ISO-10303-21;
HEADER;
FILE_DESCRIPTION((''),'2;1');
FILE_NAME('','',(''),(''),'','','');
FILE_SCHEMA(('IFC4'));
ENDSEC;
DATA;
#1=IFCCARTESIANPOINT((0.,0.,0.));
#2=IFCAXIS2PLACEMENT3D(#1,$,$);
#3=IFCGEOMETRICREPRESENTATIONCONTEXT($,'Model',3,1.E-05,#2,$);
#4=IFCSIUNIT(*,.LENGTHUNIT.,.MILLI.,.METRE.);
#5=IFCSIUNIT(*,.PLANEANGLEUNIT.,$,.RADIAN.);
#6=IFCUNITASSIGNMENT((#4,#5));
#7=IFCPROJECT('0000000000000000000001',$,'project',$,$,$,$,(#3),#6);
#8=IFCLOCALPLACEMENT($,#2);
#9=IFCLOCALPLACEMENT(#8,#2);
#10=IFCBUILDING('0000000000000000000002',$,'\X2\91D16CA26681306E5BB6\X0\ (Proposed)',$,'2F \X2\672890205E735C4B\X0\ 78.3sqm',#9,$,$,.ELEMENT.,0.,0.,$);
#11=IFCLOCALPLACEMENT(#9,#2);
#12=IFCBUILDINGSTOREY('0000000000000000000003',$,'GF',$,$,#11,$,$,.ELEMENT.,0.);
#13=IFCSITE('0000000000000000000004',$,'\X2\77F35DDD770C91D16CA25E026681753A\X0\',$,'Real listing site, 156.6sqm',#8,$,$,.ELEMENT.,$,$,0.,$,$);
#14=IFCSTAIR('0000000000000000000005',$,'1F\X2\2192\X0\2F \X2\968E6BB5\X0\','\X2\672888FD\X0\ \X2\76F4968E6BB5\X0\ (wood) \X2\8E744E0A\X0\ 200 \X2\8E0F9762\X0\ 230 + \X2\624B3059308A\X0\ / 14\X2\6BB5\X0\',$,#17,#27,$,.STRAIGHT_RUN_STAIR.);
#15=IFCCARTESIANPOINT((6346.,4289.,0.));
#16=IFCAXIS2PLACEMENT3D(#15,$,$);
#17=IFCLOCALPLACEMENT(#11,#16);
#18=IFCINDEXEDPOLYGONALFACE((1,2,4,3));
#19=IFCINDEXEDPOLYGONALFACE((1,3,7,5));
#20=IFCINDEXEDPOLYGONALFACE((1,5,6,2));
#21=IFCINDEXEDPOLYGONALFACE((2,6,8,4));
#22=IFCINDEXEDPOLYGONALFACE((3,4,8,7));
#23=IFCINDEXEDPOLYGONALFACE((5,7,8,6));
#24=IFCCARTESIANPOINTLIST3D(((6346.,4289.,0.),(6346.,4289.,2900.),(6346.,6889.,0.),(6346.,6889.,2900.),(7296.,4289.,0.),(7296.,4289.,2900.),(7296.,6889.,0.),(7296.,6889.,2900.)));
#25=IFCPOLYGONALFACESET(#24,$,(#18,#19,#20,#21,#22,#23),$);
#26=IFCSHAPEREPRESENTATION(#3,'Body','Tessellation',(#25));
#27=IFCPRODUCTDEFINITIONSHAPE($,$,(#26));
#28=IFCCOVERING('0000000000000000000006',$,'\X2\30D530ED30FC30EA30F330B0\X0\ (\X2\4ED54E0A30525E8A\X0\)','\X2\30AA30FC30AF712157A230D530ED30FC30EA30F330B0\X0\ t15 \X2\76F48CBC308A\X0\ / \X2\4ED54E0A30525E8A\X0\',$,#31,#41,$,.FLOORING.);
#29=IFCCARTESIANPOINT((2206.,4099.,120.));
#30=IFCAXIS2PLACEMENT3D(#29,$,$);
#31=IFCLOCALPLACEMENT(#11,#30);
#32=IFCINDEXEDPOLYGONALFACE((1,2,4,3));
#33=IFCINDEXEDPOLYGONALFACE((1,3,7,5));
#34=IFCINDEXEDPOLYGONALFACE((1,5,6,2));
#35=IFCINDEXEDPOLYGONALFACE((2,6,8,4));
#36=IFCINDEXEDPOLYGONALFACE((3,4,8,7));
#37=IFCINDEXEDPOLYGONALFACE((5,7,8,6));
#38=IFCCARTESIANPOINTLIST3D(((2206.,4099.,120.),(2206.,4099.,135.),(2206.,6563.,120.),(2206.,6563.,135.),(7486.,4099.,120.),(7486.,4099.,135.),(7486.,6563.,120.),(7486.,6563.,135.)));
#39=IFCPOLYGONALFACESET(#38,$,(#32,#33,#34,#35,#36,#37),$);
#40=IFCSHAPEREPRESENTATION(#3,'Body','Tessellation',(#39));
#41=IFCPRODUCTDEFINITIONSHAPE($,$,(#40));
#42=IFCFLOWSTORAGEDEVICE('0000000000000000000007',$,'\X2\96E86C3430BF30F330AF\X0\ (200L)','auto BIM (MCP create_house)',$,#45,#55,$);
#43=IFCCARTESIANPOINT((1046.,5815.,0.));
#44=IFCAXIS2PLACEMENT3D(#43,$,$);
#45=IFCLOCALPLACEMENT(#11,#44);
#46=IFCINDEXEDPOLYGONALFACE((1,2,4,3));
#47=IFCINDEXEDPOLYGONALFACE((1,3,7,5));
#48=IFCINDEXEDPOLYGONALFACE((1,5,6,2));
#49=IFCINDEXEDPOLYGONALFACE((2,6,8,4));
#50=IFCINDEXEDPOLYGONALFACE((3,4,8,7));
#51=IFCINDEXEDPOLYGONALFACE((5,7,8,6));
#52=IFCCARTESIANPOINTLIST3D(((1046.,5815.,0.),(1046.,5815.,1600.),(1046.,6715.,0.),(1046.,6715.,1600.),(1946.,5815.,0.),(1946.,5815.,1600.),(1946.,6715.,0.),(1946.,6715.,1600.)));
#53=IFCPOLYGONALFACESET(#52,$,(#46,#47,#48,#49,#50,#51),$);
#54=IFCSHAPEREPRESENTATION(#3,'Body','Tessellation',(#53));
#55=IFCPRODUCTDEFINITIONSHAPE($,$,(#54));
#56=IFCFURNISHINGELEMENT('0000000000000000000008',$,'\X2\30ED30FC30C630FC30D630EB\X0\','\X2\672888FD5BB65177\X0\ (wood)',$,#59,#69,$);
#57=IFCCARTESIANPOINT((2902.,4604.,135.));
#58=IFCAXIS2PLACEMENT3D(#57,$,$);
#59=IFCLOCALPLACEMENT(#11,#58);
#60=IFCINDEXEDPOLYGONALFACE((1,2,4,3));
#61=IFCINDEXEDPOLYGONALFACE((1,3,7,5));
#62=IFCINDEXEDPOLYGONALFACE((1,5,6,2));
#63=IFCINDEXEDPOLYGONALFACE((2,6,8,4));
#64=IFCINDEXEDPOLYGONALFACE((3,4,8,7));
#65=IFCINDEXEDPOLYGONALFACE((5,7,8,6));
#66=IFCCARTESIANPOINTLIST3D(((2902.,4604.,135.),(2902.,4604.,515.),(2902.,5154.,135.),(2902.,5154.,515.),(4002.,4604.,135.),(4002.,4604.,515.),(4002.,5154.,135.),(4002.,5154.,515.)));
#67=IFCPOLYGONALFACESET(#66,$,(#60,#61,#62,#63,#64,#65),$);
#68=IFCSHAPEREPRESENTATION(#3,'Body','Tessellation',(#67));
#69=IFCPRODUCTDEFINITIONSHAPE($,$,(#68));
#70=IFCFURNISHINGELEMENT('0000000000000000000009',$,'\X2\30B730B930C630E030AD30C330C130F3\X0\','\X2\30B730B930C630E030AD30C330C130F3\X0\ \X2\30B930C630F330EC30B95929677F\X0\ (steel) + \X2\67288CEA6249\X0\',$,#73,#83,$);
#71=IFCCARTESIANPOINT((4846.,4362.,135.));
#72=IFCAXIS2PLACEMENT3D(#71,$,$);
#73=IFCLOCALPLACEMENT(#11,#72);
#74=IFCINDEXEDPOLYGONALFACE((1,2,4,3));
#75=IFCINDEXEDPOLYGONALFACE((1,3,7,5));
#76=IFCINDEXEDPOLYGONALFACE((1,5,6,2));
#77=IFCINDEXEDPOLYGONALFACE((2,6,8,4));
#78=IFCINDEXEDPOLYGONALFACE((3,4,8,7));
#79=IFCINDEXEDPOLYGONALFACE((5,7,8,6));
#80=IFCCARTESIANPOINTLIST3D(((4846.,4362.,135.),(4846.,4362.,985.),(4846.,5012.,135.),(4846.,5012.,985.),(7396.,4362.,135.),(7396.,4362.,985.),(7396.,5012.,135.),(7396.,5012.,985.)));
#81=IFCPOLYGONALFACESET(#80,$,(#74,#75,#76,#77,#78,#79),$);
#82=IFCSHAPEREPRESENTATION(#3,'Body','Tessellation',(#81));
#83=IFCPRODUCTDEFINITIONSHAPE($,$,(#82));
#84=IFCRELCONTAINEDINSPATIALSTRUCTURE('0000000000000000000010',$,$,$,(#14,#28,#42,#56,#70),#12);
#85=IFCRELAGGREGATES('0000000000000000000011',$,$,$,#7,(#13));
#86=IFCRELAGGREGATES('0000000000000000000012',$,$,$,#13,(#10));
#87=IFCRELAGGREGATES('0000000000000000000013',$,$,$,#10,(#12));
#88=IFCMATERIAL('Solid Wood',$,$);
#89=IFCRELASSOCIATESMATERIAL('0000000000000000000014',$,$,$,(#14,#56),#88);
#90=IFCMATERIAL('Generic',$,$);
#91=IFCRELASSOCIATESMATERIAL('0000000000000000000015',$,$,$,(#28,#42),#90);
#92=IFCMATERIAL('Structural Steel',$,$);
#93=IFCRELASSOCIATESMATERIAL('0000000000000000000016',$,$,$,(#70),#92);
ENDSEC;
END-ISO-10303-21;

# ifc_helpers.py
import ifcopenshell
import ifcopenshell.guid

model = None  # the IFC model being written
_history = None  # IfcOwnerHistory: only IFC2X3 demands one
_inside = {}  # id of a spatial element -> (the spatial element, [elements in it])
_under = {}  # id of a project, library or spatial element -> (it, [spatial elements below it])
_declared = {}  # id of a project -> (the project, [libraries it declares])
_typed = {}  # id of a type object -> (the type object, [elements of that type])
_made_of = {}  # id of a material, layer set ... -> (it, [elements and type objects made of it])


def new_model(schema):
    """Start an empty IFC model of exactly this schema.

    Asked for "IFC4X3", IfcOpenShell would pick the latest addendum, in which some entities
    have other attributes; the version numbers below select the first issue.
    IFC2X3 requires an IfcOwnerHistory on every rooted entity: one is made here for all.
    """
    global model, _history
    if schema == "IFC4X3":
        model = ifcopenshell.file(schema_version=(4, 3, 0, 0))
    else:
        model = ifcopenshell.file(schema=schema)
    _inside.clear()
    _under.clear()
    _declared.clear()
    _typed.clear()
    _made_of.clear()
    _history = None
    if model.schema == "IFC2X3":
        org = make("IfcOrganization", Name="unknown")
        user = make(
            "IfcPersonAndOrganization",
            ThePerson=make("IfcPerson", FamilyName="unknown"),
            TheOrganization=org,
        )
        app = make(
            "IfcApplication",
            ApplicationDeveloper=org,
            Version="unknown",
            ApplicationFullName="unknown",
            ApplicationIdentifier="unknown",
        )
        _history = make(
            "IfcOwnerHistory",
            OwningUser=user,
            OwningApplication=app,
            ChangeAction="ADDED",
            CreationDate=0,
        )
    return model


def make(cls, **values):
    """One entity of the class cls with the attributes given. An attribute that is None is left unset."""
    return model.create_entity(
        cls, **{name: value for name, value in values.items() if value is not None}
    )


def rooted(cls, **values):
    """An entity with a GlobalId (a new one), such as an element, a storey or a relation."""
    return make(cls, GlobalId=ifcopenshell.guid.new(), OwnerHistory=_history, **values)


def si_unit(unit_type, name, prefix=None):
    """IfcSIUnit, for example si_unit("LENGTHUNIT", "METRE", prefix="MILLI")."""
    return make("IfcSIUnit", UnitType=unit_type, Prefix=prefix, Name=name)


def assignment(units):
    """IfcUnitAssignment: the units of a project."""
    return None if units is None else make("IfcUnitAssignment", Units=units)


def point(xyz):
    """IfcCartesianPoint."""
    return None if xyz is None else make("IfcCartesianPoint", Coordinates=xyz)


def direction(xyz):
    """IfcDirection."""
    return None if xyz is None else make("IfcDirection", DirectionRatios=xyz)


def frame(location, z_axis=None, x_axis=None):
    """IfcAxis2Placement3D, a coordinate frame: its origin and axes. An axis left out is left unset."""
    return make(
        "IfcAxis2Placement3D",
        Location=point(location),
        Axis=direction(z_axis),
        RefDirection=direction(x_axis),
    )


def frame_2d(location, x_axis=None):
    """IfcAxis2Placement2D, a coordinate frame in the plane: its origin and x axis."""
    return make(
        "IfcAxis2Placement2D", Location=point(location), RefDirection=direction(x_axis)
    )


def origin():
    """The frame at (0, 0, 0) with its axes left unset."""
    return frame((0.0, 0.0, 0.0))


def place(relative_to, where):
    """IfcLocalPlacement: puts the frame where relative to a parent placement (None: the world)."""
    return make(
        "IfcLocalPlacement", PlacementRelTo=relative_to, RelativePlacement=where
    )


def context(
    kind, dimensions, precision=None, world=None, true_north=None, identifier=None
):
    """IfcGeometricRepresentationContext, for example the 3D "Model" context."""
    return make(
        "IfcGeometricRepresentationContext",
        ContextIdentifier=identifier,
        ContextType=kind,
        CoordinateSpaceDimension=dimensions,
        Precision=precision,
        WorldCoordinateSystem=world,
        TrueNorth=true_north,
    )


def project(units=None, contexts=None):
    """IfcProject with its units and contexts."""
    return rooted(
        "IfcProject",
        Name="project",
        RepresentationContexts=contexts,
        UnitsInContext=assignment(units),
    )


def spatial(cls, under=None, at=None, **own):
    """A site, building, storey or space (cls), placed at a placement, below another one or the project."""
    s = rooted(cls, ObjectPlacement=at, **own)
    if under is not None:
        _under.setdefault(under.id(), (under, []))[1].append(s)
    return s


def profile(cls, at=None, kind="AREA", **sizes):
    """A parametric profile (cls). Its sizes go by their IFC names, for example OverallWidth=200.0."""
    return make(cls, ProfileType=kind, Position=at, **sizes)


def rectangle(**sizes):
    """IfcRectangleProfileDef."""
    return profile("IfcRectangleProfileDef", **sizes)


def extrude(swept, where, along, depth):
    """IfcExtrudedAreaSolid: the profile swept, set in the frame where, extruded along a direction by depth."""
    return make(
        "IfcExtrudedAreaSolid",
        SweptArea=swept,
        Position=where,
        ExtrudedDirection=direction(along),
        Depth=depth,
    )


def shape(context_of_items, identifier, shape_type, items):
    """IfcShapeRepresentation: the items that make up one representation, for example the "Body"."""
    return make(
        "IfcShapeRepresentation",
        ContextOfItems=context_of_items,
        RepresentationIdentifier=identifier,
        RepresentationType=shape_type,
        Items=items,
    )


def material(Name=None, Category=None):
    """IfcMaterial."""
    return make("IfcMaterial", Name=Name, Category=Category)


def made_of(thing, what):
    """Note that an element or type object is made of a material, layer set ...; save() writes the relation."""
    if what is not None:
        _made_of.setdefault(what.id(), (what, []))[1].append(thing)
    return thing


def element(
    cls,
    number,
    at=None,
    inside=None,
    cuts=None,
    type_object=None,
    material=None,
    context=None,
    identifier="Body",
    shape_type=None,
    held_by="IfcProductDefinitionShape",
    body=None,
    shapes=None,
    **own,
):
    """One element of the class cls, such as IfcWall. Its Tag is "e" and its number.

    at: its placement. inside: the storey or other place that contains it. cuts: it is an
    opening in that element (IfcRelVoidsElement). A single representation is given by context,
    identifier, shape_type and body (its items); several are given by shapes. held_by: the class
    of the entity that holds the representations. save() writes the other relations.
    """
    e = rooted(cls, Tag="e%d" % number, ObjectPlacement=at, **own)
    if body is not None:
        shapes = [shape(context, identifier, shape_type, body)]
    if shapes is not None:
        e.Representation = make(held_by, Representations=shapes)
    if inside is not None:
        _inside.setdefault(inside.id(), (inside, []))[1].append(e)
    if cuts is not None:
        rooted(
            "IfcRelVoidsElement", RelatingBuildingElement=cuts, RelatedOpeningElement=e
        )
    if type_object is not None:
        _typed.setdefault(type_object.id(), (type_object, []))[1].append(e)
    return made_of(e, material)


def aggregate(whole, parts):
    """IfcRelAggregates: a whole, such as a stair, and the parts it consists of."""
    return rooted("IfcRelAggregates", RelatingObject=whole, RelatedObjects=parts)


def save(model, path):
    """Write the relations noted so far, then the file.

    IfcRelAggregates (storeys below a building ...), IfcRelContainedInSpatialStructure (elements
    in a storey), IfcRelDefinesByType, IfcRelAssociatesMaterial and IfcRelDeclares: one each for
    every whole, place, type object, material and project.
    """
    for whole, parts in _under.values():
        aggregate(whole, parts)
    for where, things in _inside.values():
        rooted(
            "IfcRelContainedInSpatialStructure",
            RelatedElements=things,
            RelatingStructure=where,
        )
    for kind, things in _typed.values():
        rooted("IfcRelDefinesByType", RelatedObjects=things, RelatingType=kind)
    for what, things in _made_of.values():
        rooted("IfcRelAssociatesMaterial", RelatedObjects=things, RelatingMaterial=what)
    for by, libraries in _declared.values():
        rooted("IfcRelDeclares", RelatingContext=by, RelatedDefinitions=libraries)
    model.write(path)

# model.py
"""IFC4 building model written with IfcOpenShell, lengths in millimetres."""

from ifc_helpers import new_model, si_unit, frame, frame_2d, origin, place, context, project, spatial, rectangle, extrude, material, element, save


model = new_model("IFC4")

# Units and contexts
model_context = context("Model", 3, precision=1e-05, world=origin())
ifc_project = project(units=[si_unit("LENGTHUNIT", "METRE", prefix="MILLI"), si_unit("PLANEANGLEUNIT", "RADIAN")], contexts=[model_context])

# Site, building, storey
site_placement = place(None, origin())
site = spatial("IfcSite", under=ifc_project, at=site_placement, Name="石川県金沢市暁町", ObjectType="Real listing site, 156.6sqm", CompositionType="ELEMENT", RefElevation=0.0)
building_placement = place(site_placement, origin())
building = spatial("IfcBuilding", under=site, at=building_placement, Name="金沢暁の家 (Proposed)", ObjectType="2F 木造平屋 78.3sqm", CompositionType="ELEMENT", ElevationOfRefHeight=0.0, ElevationOfTerrain=0.0)
storey_placement = place(building_placement, origin())
storey = spatial("IfcBuildingStorey", under=building, at=storey_placement, Name="GF", CompositionType="ELEMENT", Elevation=0.0)

# Shared definitions
ifc_material_1 = material(Name="Solid Wood")

# Stair
stair_placement = place(storey_placement, frame((6346.0, 4289.0, 0.0)))
element("IfcStair", 1, at=stair_placement, inside=storey, material=ifc_material_1, Name="1F→2F 階段", Description="木製 直階段 (wood) 蹴上 200 踏面 230 + 手すり / 14段", PredefinedType="STRAIGHT_RUN_STAIR", context=model_context, shape_type="SweptSolid", body=[
    extrude(rectangle(XDim=950.0, YDim=2600.0, at=frame_2d((475.0, 1300.0))), frame((6346.0, 4289.0, 0.0)), (0.0, 0.0, 1.0), 2900.0),
])

# Covering
ifc_material_2 = material(Name="Generic")
covering_placement = place(storey_placement, frame((2206.0, 4099.0, 120.0)))
element("IfcCovering", 2, at=covering_placement, inside=storey, material=ifc_material_2, Name="フローリング (仕上げ床)", Description="オーク無垢フローリング t15 直貼り / 仕上げ床", PredefinedType="FLOORING", context=model_context, shape_type="SweptSolid", body=[
    extrude(rectangle(XDim=5280.0, YDim=2464.0, at=frame_2d((2640.0, 1232.0))), frame((2206.0, 4099.0, 120.0)), (0.0, 0.0, 1.0), 15.0),
])

# Flow storage device
flow_storage_device_placement = place(storey_placement, frame((1046.0, 5815.0, 0.0)))
element("IfcFlowStorageDevice", 3, at=flow_storage_device_placement, inside=storey, material=ifc_material_2, Name="雨水タンク (200L)", Description="auto BIM (MCP create_house)", context=model_context, shape_type="SweptSolid", body=[
    extrude(rectangle(XDim=900.0, YDim=900.0, at=frame_2d((450.0, 450.0))), frame((1046.0, 5815.0, 0.0)), (0.0, 0.0, 1.0), 1600.0),
])

# Furnishing elements
furnishing_1_placement = place(storey_placement, frame((2902.0, 4604.0, 135.0)))
element("IfcFurnishingElement", 4, at=furnishing_1_placement, inside=storey, material=ifc_material_1, Name="ローテーブル", Description="木製家具 (wood)", context=model_context, shape_type="SweptSolid", body=[
    extrude(rectangle(XDim=1100.0, YDim=550.0, at=frame_2d((550.0, 275.0))), frame((2902.0, 4604.0, 135.0)), (0.0, 0.0, 1.0), 380.0),
])
ifc_material_3 = material(Name="Structural Steel")
furnishing_2_placement = place(storey_placement, frame((4846.0, 4362.0, 135.0)))
element("IfcFurnishingElement", 5, at=furnishing_2_placement, inside=storey, material=ifc_material_3, Name="システムキッチン", Description="システムキッチン ステンレス天板 (steel) + 木質扉", context=model_context, shape_type="SweptSolid", body=[
    extrude(rectangle(XDim=2550.0, YDim=650.0, at=frame_2d((1275.0, 325.0))), frame((4846.0, 4362.0, 135.0)), (0.0, 0.0, 1.0), 850.0),
])

save(model, "model.ifc")
